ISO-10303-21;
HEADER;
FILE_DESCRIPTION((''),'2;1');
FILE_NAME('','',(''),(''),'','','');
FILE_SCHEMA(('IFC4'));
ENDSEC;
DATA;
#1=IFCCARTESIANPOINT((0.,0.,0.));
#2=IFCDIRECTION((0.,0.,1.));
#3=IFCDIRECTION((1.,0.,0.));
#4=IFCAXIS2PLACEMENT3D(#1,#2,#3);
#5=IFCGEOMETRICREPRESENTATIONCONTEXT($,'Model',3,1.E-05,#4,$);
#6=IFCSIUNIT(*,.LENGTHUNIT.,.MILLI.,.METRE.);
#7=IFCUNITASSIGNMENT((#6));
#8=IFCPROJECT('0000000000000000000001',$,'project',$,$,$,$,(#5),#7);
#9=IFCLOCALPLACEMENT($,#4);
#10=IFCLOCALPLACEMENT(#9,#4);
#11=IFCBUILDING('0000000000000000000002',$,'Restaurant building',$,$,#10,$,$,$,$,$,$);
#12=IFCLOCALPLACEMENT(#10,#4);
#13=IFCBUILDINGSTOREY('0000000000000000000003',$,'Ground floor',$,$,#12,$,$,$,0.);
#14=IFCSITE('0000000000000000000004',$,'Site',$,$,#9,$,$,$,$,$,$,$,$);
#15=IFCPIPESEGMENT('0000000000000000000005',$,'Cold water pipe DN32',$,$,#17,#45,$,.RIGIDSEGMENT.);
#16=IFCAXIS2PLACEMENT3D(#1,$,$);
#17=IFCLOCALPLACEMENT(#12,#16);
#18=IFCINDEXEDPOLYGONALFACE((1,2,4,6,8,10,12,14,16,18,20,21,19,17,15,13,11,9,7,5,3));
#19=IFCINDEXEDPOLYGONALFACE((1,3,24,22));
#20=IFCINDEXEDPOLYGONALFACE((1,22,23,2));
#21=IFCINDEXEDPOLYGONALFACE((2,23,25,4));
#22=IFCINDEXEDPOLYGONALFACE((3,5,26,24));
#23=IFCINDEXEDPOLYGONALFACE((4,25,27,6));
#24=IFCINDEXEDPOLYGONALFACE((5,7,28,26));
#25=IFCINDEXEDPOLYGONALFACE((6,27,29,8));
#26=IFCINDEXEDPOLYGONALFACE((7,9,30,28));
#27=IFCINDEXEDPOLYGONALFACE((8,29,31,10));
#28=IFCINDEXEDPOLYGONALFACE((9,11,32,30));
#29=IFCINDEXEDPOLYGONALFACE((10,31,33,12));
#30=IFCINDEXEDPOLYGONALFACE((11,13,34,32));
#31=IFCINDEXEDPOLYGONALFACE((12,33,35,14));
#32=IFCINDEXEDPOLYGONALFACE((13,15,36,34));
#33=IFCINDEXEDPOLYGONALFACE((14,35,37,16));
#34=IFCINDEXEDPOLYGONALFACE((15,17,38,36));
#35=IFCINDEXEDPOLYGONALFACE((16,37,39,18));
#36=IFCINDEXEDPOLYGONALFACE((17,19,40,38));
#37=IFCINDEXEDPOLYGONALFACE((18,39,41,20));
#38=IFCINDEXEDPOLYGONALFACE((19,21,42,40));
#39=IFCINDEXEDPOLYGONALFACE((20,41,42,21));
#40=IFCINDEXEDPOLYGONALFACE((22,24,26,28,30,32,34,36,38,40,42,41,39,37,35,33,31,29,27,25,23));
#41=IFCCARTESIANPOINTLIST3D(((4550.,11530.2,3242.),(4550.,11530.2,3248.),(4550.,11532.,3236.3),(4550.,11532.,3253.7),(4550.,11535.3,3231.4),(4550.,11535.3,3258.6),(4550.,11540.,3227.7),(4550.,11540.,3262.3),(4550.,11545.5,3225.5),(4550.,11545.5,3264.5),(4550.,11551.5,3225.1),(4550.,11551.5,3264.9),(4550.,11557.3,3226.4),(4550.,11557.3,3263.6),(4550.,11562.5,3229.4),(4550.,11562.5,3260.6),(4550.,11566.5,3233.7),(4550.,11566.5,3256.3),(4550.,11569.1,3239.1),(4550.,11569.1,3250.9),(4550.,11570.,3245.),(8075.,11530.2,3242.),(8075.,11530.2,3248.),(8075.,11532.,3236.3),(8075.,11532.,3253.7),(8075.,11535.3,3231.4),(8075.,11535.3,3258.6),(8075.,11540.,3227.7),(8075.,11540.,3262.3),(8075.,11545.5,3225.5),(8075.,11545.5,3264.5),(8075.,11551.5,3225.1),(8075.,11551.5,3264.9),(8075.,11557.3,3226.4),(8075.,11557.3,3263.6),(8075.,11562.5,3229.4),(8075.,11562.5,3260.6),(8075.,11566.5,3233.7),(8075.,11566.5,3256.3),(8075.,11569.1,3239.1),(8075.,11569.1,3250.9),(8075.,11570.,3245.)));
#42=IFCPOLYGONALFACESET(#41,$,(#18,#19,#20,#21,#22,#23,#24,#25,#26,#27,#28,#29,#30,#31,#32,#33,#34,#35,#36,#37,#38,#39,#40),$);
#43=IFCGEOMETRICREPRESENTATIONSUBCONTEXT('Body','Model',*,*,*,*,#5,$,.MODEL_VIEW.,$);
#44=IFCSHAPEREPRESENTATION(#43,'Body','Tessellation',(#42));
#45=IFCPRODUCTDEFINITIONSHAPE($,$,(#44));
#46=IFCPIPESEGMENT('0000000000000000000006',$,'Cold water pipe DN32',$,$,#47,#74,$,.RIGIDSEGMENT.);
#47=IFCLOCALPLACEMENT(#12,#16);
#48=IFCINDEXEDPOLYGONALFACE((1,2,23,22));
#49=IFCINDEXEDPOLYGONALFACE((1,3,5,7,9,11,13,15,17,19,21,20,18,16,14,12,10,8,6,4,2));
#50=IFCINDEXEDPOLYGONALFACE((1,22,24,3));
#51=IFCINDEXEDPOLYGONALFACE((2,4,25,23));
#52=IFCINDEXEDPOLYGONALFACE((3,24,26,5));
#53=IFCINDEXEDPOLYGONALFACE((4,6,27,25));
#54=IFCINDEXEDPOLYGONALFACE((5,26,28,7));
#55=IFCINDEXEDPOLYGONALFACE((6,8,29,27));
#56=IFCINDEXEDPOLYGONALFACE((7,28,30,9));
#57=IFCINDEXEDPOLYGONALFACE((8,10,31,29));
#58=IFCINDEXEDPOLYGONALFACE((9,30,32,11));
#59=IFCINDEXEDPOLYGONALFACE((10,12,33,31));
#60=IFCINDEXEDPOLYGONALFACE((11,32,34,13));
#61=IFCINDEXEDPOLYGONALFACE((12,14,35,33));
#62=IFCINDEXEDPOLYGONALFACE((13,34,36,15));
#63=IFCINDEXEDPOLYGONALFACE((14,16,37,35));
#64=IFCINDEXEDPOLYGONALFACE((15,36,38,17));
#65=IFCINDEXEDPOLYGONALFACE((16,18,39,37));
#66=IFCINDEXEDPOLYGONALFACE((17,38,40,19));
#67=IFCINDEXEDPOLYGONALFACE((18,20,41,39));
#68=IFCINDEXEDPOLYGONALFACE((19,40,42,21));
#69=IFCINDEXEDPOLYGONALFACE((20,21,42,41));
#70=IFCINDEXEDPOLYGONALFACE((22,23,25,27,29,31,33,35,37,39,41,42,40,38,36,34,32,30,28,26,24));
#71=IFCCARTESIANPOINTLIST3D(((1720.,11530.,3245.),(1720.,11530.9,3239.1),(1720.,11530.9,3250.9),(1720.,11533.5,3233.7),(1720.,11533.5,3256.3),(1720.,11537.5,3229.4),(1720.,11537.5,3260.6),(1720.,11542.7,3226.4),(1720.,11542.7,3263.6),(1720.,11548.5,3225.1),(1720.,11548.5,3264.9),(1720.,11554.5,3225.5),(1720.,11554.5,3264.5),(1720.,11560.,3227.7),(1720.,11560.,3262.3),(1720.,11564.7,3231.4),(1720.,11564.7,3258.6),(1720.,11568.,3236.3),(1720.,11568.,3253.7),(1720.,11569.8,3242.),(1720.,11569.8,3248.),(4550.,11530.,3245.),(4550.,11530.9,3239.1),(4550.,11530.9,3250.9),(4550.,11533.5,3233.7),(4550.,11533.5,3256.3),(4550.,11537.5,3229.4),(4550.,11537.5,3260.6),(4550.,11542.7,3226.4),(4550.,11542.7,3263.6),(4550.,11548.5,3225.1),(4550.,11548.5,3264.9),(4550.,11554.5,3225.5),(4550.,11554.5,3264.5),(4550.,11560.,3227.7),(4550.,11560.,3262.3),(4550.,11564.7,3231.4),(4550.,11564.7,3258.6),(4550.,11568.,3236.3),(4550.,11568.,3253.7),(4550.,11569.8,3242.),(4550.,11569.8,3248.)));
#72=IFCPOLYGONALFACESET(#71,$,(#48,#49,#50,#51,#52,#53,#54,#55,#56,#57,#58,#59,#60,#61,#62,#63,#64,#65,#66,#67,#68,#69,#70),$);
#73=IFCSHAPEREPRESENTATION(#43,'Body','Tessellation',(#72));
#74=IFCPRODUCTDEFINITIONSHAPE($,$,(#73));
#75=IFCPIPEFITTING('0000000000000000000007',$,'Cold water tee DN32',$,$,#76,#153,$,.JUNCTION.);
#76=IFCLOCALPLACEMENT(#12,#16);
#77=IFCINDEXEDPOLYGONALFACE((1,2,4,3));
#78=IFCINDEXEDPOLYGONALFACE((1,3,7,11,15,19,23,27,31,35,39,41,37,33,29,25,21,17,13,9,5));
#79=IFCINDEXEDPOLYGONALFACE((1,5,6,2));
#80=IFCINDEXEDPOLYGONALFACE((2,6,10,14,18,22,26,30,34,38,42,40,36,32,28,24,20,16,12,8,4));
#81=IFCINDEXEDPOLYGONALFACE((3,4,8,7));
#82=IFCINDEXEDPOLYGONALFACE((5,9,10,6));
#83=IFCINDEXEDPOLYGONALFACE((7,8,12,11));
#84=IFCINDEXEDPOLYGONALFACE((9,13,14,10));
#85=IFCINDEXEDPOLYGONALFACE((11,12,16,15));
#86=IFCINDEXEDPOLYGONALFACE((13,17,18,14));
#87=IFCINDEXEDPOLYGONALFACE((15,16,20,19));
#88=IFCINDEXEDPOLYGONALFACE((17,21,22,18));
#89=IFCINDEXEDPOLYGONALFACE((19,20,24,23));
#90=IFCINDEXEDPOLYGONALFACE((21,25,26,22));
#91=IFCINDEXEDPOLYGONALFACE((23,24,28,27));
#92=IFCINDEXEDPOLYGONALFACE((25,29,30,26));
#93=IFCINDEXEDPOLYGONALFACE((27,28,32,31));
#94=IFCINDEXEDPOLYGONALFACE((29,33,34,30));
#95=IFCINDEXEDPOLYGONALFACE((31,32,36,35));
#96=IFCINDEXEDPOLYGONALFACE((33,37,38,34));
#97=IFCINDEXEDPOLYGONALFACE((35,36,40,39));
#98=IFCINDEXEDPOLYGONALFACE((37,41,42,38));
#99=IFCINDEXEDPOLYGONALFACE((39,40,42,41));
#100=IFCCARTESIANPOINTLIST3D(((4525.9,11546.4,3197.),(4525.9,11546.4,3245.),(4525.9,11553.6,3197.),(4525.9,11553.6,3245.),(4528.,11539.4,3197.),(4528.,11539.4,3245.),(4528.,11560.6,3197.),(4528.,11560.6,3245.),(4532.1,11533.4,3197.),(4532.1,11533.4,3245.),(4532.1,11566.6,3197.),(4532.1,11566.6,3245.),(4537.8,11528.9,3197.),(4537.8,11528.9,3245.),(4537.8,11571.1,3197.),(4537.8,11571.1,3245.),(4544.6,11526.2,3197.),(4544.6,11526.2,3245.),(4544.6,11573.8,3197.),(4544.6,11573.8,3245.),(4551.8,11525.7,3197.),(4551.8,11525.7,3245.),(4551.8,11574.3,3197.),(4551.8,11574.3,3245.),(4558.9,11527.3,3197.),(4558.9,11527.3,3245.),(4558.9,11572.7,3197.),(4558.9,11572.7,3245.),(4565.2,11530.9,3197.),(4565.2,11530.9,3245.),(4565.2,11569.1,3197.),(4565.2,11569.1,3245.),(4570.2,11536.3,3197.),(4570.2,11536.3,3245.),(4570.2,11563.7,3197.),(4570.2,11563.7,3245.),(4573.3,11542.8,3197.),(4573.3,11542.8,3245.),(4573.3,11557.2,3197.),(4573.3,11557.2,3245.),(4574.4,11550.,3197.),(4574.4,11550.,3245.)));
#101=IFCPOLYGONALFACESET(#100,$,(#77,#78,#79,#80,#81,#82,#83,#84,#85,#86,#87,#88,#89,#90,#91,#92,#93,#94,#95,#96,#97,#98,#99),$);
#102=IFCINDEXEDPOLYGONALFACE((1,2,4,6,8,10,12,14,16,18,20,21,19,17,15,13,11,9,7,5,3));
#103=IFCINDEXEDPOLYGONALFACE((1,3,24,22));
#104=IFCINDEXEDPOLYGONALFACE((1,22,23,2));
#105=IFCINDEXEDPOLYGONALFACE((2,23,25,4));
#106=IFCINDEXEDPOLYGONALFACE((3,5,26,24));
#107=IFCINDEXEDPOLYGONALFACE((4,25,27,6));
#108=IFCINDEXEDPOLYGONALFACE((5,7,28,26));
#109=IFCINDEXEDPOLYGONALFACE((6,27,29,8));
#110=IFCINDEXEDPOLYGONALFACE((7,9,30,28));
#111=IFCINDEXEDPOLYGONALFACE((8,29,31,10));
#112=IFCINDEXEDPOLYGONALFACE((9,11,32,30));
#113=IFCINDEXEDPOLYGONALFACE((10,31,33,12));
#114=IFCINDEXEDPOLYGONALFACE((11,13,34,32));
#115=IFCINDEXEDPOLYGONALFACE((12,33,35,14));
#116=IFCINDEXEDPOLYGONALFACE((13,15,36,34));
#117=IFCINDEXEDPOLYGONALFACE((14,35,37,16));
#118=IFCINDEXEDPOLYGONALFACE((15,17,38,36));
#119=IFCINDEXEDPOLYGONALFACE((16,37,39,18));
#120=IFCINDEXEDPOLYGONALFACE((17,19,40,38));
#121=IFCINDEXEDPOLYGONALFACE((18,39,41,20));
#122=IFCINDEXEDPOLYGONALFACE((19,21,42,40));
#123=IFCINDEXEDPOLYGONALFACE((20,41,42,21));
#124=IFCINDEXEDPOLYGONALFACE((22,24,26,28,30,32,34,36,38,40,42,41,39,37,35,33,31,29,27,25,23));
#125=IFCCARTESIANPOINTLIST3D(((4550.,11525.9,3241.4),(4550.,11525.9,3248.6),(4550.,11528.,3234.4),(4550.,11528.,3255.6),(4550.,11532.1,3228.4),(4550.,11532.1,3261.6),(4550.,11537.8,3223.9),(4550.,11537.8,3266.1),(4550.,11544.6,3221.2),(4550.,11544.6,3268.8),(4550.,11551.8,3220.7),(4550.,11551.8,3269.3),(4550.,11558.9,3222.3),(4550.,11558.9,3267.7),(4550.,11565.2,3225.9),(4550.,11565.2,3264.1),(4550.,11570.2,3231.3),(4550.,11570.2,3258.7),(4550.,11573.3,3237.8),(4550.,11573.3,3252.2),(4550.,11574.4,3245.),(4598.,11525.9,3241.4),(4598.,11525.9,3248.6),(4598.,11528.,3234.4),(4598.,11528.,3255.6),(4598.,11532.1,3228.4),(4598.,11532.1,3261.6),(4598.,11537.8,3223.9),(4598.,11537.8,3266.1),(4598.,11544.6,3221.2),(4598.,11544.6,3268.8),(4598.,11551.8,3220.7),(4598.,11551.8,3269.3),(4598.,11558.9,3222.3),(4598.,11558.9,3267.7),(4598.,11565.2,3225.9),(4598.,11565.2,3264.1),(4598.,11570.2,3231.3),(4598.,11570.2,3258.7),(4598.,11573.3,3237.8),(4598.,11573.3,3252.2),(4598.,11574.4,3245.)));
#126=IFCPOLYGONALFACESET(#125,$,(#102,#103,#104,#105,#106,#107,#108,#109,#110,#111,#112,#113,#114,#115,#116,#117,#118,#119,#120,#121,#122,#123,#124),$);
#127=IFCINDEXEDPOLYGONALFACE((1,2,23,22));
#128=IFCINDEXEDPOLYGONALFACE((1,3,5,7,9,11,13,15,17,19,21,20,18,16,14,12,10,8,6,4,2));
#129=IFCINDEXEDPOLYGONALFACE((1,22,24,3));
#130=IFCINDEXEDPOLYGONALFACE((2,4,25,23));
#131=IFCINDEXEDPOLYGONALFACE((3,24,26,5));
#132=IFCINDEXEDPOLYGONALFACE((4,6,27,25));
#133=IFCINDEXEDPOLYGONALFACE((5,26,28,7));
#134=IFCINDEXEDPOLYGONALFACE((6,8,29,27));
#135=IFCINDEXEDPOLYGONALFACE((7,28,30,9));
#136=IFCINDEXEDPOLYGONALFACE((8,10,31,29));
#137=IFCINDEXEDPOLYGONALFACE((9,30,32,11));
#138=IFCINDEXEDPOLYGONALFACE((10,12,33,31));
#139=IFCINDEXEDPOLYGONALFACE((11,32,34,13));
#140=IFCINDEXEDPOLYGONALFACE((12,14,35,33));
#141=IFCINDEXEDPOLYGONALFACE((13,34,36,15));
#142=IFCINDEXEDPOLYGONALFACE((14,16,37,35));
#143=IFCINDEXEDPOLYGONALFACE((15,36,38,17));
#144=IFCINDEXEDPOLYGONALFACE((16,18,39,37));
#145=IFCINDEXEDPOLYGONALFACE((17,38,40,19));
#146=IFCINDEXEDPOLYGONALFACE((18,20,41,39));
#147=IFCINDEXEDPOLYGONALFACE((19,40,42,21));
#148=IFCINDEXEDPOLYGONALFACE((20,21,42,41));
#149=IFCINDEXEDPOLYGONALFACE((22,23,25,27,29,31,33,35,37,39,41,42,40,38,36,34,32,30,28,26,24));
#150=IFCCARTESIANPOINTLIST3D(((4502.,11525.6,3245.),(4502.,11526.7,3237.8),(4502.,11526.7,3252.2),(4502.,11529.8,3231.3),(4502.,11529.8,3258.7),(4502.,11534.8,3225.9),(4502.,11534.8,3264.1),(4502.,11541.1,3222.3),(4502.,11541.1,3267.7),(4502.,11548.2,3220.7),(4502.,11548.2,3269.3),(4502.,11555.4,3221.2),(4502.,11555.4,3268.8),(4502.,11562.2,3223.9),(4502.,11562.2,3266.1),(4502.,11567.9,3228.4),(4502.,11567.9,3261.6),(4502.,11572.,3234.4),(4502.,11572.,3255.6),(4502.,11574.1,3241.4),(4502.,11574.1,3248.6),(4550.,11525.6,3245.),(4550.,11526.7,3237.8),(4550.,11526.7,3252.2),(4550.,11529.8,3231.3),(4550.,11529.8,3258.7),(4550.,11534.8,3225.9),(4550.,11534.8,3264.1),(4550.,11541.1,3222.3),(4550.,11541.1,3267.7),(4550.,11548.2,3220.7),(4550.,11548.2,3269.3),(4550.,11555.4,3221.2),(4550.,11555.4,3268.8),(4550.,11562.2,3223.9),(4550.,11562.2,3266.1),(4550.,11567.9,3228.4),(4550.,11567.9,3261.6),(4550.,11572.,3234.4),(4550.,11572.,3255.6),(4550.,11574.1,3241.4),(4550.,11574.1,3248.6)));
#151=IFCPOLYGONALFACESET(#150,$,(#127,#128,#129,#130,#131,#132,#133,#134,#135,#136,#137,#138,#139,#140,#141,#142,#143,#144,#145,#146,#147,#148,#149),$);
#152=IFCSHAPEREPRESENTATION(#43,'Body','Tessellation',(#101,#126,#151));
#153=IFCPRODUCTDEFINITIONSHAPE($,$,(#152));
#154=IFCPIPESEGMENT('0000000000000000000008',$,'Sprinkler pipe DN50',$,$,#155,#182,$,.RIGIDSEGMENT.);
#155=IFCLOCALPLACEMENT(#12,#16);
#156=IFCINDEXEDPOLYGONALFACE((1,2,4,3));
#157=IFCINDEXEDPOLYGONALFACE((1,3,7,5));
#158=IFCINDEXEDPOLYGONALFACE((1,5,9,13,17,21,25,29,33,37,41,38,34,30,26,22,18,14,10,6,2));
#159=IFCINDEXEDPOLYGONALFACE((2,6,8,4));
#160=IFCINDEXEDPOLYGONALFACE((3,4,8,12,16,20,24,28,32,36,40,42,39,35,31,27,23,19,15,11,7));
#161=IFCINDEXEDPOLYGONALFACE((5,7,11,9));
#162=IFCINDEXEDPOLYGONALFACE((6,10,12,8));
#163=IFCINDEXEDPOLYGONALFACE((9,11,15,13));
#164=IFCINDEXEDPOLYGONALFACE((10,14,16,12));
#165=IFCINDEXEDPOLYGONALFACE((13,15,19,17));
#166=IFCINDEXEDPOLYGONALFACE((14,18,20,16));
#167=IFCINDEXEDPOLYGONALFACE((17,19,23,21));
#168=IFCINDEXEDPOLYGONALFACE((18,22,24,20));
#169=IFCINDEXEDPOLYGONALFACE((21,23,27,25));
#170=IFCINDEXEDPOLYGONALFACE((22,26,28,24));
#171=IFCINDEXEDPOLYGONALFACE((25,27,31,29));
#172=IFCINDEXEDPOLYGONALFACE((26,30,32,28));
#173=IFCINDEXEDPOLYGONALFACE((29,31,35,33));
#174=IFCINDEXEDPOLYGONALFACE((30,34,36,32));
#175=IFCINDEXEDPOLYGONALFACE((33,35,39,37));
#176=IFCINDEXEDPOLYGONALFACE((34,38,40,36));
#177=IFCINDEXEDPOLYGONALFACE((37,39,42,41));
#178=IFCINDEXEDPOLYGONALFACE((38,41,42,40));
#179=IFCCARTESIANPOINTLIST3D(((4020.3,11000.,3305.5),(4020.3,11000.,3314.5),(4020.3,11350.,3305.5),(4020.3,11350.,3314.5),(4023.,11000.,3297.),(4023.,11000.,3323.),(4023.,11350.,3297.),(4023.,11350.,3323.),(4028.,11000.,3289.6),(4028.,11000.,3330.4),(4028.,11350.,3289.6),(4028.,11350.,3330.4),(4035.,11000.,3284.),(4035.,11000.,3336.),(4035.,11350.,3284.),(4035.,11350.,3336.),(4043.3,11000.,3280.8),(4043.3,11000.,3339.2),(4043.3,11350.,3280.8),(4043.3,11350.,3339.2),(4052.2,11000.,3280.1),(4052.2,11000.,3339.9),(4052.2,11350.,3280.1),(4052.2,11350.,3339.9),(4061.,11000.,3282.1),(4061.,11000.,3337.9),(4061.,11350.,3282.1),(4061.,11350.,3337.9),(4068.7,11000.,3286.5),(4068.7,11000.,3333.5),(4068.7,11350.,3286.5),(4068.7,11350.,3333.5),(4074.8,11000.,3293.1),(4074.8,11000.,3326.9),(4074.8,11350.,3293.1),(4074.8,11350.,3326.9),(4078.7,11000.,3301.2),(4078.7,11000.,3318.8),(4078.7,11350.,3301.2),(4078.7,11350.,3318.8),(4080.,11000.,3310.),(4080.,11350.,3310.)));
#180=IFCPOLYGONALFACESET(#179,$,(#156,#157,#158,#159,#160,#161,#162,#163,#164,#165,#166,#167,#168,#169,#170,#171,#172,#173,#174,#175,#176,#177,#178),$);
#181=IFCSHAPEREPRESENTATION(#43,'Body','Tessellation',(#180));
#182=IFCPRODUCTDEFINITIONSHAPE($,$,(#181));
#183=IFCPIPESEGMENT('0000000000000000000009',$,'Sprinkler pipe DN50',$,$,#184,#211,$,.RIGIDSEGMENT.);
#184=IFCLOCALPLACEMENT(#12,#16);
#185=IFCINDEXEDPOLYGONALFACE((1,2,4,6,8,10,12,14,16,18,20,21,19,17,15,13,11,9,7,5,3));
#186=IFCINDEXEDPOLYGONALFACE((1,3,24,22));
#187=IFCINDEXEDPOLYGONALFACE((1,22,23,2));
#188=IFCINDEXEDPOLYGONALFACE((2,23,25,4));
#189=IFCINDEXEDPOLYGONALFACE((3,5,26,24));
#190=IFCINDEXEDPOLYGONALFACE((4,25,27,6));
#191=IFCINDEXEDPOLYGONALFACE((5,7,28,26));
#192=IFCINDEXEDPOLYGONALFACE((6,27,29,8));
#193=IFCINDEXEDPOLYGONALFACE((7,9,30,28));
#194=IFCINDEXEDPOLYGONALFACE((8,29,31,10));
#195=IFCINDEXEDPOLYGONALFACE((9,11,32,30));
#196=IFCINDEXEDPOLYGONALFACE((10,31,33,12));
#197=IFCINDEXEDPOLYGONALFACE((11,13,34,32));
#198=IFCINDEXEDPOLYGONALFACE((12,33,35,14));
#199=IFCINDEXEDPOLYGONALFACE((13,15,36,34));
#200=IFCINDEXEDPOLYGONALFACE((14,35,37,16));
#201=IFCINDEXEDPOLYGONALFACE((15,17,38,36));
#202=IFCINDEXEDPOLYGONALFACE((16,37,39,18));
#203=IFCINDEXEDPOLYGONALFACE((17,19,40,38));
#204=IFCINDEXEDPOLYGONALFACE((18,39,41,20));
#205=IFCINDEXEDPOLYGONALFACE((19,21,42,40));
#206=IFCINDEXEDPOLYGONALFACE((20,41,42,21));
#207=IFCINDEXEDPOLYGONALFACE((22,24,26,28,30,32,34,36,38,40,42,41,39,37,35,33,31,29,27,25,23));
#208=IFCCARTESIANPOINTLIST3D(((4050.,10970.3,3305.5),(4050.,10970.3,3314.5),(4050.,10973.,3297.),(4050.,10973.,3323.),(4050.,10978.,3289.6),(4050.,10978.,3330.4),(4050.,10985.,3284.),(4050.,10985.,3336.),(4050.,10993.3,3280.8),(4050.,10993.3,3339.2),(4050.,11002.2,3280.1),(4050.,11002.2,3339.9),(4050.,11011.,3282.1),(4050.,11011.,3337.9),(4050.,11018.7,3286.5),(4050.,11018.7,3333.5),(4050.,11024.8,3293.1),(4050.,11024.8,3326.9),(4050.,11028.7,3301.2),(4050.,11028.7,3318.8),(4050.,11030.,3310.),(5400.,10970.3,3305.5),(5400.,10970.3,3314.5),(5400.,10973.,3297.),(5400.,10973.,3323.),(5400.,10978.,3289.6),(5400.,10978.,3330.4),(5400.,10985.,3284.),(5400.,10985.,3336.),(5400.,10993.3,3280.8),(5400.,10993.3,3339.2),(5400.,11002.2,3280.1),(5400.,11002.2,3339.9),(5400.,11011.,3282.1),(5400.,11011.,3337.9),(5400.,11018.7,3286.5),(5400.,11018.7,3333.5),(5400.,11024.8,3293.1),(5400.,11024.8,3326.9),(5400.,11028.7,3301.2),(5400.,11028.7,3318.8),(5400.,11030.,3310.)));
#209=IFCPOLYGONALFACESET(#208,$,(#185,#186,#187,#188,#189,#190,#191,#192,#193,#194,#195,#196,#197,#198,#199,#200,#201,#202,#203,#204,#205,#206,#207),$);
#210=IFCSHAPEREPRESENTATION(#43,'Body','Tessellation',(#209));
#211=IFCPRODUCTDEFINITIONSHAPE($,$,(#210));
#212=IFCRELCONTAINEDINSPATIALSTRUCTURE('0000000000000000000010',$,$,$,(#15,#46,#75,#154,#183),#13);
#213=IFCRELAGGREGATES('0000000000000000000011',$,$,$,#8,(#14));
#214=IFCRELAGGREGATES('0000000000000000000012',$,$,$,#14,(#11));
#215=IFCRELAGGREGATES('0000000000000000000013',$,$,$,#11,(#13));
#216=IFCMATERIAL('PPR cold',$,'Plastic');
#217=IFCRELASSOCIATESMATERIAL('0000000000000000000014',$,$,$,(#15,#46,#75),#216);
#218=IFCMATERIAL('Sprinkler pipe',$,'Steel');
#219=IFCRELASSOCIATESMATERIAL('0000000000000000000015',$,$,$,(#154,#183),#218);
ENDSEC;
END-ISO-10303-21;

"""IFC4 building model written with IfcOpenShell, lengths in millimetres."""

from ifc_helpers import new_model, si_unit, frame, origin_with_axes, origin_2d, place, context, subcontext, project, spatial, circle, extrude, material, element, save


model = new_model("IFC4")

# Units and contexts
model_context = context("Model", 3, precision=1e-05, world=origin_with_axes())
body_context = subcontext(model_context, "Body", "Model", "MODEL_VIEW")
ifc_project = project(units=[si_unit("LENGTHUNIT", "METRE", prefix="MILLI")], contexts=[model_context])

# Site, building, storey
site_placement = place(None, origin_with_axes())
site = spatial("IfcSite", under=ifc_project, at=site_placement, Name="Site")
building_placement = place(site_placement, origin_with_axes())
building = spatial("IfcBuilding", under=site, at=building_placement, Name="Restaurant building")
storey_placement = place(building_placement, origin_with_axes())
storey = spatial("IfcBuildingStorey", under=building, at=storey_placement, Name="Ground floor", Elevation=0.0)

# Pipe segments
ifc_material_1 = material(Name="PPR cold", Category="Plastic")
pipe_segment_1_placement = place(storey_placement, frame((4550.0, 11550.0, 3245.0)))
element("IfcPipeSegment", 1, at=pipe_segment_1_placement, inside=storey, material=ifc_material_1, Name="Cold water pipe DN32", PredefinedType="RIGIDSEGMENT", context=body_context, shape_type="SweptSolid", body=[
    extrude(circle(Radius=20.0, at=origin_2d()), frame((0.0, 0.0, 0.0), z_axis=(1.0, 0.0, 0.0), x_axis=(0.0, 1.0, 0.0)), (0.0, 0.0, 1.0), 3525.0),
])
pipe_segment_2_placement = place(storey_placement, frame((4550.0, 11550.0, 3245.0)))
element("IfcPipeSegment", 2, at=pipe_segment_2_placement, inside=storey, material=ifc_material_1, Name="Cold water pipe DN32", PredefinedType="RIGIDSEGMENT", context=body_context, shape_type="SweptSolid", body=[
    extrude(circle(Radius=20.0, at=origin_2d()), frame((0.0, 0.0, 0.0), z_axis=(-1.0, 0.0, 0.0), x_axis=(0.0, -1.0, 0.0)), (0.0, 0.0, 1.0), 2830.0),
])

# Pipe fitting
pipe_fitting_1_placement = place(storey_placement, frame((4550.0, 11550.0, 3245.0)))
element("IfcPipeFitting", 3, at=pipe_fitting_1_placement, inside=storey, material=ifc_material_1, Name="Cold water tee DN32", PredefinedType="JUNCTION", context=body_context, shape_type="SweptSolid", body=[
    extrude(circle(Radius=24.4, at=origin_2d()), frame((0.0, 0.0, 0.0), z_axis=(0.0, 0.0, -1.0), x_axis=(1.0, 0.0, 0.0)), (0.0, 0.0, 1.0), 48.0),
    extrude(circle(Radius=24.4, at=origin_2d()), frame((0.0, 0.0, 0.0), z_axis=(1.0, 0.0, 0.0), x_axis=(0.0, 1.0, 0.0)), (0.0, 0.0, 1.0), 48.0),
    extrude(circle(Radius=24.4, at=origin_2d()), frame((0.0, 0.0, 0.0), z_axis=(-1.0, 0.0, 0.0), x_axis=(0.0, -1.0, 0.0)), (0.0, 0.0, 1.0), 48.0),
])

# Pipe segments
ifc_material_2 = material(Name="Sprinkler pipe", Category="Steel")
pipe_segment_3_placement = place(storey_placement, frame((4050.0, 11350.0, 3310.0)))
element("IfcPipeSegment", 4, at=pipe_segment_3_placement, inside=storey, material=ifc_material_2, Name="Sprinkler pipe DN50", PredefinedType="RIGIDSEGMENT", context=body_context, shape_type="SweptSolid", body=[
    extrude(circle(Radius=30.0, at=origin_2d()), frame((0.0, 0.0, 0.0), z_axis=(0.0, -1.0, 0.0), x_axis=(1.0, 0.0, 0.0)), (0.0, 0.0, 1.0), 350.0),
])
pipe_segment_4_placement = place(storey_placement, frame((4050.0, 11000.0, 3310.0)))
element("IfcPipeSegment", 5, at=pipe_segment_4_placement, inside=storey, material=ifc_material_2, Name="Sprinkler pipe DN50", PredefinedType="RIGIDSEGMENT", context=body_context, shape_type="SweptSolid", body=[
    extrude(circle(Radius=30.0, at=origin_2d()), frame((0.0, 0.0, 0.0), z_axis=(1.0, 0.0, 0.0), x_axis=(0.0, 1.0, 0.0)), (0.0, 0.0, 1.0), 1350.0),
])

save(model, "model.ifc")
